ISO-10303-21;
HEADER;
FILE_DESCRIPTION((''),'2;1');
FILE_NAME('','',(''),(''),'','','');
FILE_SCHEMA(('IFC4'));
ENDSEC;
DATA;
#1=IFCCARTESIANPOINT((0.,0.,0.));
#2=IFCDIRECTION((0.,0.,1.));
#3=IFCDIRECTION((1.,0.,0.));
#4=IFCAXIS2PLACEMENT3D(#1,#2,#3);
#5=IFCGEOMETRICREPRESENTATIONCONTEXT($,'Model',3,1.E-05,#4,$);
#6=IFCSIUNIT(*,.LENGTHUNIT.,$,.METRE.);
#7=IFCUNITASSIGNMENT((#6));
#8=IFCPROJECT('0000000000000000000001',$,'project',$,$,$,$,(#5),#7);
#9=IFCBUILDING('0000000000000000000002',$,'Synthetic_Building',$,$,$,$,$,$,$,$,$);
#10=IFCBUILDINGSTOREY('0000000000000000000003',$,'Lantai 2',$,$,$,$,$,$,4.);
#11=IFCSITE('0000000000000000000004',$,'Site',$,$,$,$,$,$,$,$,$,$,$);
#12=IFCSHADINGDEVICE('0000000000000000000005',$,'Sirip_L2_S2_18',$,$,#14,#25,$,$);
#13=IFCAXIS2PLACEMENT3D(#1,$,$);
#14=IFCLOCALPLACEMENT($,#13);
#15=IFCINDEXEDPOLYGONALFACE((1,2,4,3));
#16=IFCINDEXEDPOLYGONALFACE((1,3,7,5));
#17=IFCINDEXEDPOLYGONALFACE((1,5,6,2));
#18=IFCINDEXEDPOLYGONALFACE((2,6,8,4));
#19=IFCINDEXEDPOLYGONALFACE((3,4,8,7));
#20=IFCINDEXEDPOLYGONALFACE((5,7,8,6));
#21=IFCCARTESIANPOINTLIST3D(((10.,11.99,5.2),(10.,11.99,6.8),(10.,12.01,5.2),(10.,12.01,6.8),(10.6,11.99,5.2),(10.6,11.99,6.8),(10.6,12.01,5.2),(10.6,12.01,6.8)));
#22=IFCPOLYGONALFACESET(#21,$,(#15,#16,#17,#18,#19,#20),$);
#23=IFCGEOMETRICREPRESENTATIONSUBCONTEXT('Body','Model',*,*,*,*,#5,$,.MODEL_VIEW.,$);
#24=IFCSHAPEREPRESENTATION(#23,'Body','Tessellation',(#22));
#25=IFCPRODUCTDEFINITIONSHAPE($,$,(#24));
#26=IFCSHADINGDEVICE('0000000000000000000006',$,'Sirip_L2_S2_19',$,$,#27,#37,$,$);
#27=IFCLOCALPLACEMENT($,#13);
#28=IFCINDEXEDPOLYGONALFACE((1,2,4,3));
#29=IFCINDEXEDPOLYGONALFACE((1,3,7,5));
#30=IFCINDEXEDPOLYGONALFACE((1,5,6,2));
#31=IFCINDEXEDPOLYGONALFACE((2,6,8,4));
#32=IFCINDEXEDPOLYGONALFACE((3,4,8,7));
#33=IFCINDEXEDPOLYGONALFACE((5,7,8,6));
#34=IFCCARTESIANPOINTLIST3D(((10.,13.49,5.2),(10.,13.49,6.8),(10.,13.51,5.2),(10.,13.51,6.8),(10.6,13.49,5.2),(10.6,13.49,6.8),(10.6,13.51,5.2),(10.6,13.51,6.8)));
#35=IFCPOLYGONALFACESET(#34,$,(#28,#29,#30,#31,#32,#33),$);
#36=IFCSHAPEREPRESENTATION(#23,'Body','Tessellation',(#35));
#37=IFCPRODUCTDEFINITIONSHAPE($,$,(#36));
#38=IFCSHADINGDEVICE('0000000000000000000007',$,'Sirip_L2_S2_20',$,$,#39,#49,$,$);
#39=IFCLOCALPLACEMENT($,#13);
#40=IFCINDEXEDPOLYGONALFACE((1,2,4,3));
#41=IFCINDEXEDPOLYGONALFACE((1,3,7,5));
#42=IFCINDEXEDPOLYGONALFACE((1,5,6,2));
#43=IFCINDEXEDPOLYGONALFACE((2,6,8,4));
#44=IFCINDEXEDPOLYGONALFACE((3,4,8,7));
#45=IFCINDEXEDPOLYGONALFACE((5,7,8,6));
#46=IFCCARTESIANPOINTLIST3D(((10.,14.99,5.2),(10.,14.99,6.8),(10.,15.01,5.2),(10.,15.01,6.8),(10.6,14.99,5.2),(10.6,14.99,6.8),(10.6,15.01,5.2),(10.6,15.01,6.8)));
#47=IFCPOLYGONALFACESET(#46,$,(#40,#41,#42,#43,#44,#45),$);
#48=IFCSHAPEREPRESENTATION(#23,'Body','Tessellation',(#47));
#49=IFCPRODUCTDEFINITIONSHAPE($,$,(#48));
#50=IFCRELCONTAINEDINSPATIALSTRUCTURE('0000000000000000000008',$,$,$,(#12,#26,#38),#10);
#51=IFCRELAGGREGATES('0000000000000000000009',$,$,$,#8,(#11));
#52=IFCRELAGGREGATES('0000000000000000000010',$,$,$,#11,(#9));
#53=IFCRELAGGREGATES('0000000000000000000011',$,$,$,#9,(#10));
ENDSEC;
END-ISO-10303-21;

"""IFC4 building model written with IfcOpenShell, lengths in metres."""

from ifc_helpers import new_model, si_unit, frame, origin_with_axes, place, context, subcontext, project, spatial, polyline, outline, extrude, element, save


model = new_model("IFC4")

# Units and contexts
model_context = context("Model", 3, precision=1e-05, world=origin_with_axes())
body_context = subcontext(model_context, "Body", "Model", "MODEL_VIEW")
ifc_project = project(units=[si_unit("LENGTHUNIT", "METRE")], contexts=[model_context])

# Site, building, storey
site = spatial("IfcSite", under=ifc_project, Name="Site")
building = spatial("IfcBuilding", under=site, Name="Synthetic_Building")
storey = spatial("IfcBuildingStorey", under=building, Name="Lantai 2", Elevation=4.0)

# Shading devices
shading_device_1_placement = place(None, origin_with_axes())
element("IfcShadingDevice", 1, at=shading_device_1_placement, inside=storey, Name="Sirip_L2_S2_18", context=body_context, shape_type="SweptSolid", body=[
    extrude(outline(polyline([(10.0, 11.99), (10.0, 12.01), (10.6, 12.01), (10.6, 11.99), (10.0, 11.99)])), frame((0.0, 0.0, 5.2), z_axis=(0.0, 0.0, 1.0), x_axis=(1.0, 0.0, 0.0)), (0.0, 0.0, 1.0), 1.6),
])
shading_device_2_placement = place(None, origin_with_axes())
element("IfcShadingDevice", 2, at=shading_device_2_placement, inside=storey, Name="Sirip_L2_S2_19", context=body_context, shape_type="SweptSolid", body=[
    extrude(outline(polyline([(10.0, 13.49), (10.0, 13.51), (10.6, 13.51), (10.6, 13.49), (10.0, 13.49)])), frame((0.0, 0.0, 5.2), z_axis=(0.0, 0.0, 1.0), x_axis=(1.0, 0.0, 0.0)), (0.0, 0.0, 1.0), 1.6),
])
shading_device_3_placement = place(None, origin_with_axes())
element("IfcShadingDevice", 3, at=shading_device_3_placement, inside=storey, Name="Sirip_L2_S2_20", context=body_context, shape_type="SweptSolid", body=[
    extrude(outline(polyline([(10.0, 14.99), (10.0, 15.01), (10.6, 15.01), (10.6, 14.99), (10.0, 14.99)])), frame((0.0, 0.0, 5.2), z_axis=(0.0, 0.0, 1.0), x_axis=(1.0, 0.0, 0.0)), (0.0, 0.0, 1.0), 1.6),
])

save(model, "model.ifc")
